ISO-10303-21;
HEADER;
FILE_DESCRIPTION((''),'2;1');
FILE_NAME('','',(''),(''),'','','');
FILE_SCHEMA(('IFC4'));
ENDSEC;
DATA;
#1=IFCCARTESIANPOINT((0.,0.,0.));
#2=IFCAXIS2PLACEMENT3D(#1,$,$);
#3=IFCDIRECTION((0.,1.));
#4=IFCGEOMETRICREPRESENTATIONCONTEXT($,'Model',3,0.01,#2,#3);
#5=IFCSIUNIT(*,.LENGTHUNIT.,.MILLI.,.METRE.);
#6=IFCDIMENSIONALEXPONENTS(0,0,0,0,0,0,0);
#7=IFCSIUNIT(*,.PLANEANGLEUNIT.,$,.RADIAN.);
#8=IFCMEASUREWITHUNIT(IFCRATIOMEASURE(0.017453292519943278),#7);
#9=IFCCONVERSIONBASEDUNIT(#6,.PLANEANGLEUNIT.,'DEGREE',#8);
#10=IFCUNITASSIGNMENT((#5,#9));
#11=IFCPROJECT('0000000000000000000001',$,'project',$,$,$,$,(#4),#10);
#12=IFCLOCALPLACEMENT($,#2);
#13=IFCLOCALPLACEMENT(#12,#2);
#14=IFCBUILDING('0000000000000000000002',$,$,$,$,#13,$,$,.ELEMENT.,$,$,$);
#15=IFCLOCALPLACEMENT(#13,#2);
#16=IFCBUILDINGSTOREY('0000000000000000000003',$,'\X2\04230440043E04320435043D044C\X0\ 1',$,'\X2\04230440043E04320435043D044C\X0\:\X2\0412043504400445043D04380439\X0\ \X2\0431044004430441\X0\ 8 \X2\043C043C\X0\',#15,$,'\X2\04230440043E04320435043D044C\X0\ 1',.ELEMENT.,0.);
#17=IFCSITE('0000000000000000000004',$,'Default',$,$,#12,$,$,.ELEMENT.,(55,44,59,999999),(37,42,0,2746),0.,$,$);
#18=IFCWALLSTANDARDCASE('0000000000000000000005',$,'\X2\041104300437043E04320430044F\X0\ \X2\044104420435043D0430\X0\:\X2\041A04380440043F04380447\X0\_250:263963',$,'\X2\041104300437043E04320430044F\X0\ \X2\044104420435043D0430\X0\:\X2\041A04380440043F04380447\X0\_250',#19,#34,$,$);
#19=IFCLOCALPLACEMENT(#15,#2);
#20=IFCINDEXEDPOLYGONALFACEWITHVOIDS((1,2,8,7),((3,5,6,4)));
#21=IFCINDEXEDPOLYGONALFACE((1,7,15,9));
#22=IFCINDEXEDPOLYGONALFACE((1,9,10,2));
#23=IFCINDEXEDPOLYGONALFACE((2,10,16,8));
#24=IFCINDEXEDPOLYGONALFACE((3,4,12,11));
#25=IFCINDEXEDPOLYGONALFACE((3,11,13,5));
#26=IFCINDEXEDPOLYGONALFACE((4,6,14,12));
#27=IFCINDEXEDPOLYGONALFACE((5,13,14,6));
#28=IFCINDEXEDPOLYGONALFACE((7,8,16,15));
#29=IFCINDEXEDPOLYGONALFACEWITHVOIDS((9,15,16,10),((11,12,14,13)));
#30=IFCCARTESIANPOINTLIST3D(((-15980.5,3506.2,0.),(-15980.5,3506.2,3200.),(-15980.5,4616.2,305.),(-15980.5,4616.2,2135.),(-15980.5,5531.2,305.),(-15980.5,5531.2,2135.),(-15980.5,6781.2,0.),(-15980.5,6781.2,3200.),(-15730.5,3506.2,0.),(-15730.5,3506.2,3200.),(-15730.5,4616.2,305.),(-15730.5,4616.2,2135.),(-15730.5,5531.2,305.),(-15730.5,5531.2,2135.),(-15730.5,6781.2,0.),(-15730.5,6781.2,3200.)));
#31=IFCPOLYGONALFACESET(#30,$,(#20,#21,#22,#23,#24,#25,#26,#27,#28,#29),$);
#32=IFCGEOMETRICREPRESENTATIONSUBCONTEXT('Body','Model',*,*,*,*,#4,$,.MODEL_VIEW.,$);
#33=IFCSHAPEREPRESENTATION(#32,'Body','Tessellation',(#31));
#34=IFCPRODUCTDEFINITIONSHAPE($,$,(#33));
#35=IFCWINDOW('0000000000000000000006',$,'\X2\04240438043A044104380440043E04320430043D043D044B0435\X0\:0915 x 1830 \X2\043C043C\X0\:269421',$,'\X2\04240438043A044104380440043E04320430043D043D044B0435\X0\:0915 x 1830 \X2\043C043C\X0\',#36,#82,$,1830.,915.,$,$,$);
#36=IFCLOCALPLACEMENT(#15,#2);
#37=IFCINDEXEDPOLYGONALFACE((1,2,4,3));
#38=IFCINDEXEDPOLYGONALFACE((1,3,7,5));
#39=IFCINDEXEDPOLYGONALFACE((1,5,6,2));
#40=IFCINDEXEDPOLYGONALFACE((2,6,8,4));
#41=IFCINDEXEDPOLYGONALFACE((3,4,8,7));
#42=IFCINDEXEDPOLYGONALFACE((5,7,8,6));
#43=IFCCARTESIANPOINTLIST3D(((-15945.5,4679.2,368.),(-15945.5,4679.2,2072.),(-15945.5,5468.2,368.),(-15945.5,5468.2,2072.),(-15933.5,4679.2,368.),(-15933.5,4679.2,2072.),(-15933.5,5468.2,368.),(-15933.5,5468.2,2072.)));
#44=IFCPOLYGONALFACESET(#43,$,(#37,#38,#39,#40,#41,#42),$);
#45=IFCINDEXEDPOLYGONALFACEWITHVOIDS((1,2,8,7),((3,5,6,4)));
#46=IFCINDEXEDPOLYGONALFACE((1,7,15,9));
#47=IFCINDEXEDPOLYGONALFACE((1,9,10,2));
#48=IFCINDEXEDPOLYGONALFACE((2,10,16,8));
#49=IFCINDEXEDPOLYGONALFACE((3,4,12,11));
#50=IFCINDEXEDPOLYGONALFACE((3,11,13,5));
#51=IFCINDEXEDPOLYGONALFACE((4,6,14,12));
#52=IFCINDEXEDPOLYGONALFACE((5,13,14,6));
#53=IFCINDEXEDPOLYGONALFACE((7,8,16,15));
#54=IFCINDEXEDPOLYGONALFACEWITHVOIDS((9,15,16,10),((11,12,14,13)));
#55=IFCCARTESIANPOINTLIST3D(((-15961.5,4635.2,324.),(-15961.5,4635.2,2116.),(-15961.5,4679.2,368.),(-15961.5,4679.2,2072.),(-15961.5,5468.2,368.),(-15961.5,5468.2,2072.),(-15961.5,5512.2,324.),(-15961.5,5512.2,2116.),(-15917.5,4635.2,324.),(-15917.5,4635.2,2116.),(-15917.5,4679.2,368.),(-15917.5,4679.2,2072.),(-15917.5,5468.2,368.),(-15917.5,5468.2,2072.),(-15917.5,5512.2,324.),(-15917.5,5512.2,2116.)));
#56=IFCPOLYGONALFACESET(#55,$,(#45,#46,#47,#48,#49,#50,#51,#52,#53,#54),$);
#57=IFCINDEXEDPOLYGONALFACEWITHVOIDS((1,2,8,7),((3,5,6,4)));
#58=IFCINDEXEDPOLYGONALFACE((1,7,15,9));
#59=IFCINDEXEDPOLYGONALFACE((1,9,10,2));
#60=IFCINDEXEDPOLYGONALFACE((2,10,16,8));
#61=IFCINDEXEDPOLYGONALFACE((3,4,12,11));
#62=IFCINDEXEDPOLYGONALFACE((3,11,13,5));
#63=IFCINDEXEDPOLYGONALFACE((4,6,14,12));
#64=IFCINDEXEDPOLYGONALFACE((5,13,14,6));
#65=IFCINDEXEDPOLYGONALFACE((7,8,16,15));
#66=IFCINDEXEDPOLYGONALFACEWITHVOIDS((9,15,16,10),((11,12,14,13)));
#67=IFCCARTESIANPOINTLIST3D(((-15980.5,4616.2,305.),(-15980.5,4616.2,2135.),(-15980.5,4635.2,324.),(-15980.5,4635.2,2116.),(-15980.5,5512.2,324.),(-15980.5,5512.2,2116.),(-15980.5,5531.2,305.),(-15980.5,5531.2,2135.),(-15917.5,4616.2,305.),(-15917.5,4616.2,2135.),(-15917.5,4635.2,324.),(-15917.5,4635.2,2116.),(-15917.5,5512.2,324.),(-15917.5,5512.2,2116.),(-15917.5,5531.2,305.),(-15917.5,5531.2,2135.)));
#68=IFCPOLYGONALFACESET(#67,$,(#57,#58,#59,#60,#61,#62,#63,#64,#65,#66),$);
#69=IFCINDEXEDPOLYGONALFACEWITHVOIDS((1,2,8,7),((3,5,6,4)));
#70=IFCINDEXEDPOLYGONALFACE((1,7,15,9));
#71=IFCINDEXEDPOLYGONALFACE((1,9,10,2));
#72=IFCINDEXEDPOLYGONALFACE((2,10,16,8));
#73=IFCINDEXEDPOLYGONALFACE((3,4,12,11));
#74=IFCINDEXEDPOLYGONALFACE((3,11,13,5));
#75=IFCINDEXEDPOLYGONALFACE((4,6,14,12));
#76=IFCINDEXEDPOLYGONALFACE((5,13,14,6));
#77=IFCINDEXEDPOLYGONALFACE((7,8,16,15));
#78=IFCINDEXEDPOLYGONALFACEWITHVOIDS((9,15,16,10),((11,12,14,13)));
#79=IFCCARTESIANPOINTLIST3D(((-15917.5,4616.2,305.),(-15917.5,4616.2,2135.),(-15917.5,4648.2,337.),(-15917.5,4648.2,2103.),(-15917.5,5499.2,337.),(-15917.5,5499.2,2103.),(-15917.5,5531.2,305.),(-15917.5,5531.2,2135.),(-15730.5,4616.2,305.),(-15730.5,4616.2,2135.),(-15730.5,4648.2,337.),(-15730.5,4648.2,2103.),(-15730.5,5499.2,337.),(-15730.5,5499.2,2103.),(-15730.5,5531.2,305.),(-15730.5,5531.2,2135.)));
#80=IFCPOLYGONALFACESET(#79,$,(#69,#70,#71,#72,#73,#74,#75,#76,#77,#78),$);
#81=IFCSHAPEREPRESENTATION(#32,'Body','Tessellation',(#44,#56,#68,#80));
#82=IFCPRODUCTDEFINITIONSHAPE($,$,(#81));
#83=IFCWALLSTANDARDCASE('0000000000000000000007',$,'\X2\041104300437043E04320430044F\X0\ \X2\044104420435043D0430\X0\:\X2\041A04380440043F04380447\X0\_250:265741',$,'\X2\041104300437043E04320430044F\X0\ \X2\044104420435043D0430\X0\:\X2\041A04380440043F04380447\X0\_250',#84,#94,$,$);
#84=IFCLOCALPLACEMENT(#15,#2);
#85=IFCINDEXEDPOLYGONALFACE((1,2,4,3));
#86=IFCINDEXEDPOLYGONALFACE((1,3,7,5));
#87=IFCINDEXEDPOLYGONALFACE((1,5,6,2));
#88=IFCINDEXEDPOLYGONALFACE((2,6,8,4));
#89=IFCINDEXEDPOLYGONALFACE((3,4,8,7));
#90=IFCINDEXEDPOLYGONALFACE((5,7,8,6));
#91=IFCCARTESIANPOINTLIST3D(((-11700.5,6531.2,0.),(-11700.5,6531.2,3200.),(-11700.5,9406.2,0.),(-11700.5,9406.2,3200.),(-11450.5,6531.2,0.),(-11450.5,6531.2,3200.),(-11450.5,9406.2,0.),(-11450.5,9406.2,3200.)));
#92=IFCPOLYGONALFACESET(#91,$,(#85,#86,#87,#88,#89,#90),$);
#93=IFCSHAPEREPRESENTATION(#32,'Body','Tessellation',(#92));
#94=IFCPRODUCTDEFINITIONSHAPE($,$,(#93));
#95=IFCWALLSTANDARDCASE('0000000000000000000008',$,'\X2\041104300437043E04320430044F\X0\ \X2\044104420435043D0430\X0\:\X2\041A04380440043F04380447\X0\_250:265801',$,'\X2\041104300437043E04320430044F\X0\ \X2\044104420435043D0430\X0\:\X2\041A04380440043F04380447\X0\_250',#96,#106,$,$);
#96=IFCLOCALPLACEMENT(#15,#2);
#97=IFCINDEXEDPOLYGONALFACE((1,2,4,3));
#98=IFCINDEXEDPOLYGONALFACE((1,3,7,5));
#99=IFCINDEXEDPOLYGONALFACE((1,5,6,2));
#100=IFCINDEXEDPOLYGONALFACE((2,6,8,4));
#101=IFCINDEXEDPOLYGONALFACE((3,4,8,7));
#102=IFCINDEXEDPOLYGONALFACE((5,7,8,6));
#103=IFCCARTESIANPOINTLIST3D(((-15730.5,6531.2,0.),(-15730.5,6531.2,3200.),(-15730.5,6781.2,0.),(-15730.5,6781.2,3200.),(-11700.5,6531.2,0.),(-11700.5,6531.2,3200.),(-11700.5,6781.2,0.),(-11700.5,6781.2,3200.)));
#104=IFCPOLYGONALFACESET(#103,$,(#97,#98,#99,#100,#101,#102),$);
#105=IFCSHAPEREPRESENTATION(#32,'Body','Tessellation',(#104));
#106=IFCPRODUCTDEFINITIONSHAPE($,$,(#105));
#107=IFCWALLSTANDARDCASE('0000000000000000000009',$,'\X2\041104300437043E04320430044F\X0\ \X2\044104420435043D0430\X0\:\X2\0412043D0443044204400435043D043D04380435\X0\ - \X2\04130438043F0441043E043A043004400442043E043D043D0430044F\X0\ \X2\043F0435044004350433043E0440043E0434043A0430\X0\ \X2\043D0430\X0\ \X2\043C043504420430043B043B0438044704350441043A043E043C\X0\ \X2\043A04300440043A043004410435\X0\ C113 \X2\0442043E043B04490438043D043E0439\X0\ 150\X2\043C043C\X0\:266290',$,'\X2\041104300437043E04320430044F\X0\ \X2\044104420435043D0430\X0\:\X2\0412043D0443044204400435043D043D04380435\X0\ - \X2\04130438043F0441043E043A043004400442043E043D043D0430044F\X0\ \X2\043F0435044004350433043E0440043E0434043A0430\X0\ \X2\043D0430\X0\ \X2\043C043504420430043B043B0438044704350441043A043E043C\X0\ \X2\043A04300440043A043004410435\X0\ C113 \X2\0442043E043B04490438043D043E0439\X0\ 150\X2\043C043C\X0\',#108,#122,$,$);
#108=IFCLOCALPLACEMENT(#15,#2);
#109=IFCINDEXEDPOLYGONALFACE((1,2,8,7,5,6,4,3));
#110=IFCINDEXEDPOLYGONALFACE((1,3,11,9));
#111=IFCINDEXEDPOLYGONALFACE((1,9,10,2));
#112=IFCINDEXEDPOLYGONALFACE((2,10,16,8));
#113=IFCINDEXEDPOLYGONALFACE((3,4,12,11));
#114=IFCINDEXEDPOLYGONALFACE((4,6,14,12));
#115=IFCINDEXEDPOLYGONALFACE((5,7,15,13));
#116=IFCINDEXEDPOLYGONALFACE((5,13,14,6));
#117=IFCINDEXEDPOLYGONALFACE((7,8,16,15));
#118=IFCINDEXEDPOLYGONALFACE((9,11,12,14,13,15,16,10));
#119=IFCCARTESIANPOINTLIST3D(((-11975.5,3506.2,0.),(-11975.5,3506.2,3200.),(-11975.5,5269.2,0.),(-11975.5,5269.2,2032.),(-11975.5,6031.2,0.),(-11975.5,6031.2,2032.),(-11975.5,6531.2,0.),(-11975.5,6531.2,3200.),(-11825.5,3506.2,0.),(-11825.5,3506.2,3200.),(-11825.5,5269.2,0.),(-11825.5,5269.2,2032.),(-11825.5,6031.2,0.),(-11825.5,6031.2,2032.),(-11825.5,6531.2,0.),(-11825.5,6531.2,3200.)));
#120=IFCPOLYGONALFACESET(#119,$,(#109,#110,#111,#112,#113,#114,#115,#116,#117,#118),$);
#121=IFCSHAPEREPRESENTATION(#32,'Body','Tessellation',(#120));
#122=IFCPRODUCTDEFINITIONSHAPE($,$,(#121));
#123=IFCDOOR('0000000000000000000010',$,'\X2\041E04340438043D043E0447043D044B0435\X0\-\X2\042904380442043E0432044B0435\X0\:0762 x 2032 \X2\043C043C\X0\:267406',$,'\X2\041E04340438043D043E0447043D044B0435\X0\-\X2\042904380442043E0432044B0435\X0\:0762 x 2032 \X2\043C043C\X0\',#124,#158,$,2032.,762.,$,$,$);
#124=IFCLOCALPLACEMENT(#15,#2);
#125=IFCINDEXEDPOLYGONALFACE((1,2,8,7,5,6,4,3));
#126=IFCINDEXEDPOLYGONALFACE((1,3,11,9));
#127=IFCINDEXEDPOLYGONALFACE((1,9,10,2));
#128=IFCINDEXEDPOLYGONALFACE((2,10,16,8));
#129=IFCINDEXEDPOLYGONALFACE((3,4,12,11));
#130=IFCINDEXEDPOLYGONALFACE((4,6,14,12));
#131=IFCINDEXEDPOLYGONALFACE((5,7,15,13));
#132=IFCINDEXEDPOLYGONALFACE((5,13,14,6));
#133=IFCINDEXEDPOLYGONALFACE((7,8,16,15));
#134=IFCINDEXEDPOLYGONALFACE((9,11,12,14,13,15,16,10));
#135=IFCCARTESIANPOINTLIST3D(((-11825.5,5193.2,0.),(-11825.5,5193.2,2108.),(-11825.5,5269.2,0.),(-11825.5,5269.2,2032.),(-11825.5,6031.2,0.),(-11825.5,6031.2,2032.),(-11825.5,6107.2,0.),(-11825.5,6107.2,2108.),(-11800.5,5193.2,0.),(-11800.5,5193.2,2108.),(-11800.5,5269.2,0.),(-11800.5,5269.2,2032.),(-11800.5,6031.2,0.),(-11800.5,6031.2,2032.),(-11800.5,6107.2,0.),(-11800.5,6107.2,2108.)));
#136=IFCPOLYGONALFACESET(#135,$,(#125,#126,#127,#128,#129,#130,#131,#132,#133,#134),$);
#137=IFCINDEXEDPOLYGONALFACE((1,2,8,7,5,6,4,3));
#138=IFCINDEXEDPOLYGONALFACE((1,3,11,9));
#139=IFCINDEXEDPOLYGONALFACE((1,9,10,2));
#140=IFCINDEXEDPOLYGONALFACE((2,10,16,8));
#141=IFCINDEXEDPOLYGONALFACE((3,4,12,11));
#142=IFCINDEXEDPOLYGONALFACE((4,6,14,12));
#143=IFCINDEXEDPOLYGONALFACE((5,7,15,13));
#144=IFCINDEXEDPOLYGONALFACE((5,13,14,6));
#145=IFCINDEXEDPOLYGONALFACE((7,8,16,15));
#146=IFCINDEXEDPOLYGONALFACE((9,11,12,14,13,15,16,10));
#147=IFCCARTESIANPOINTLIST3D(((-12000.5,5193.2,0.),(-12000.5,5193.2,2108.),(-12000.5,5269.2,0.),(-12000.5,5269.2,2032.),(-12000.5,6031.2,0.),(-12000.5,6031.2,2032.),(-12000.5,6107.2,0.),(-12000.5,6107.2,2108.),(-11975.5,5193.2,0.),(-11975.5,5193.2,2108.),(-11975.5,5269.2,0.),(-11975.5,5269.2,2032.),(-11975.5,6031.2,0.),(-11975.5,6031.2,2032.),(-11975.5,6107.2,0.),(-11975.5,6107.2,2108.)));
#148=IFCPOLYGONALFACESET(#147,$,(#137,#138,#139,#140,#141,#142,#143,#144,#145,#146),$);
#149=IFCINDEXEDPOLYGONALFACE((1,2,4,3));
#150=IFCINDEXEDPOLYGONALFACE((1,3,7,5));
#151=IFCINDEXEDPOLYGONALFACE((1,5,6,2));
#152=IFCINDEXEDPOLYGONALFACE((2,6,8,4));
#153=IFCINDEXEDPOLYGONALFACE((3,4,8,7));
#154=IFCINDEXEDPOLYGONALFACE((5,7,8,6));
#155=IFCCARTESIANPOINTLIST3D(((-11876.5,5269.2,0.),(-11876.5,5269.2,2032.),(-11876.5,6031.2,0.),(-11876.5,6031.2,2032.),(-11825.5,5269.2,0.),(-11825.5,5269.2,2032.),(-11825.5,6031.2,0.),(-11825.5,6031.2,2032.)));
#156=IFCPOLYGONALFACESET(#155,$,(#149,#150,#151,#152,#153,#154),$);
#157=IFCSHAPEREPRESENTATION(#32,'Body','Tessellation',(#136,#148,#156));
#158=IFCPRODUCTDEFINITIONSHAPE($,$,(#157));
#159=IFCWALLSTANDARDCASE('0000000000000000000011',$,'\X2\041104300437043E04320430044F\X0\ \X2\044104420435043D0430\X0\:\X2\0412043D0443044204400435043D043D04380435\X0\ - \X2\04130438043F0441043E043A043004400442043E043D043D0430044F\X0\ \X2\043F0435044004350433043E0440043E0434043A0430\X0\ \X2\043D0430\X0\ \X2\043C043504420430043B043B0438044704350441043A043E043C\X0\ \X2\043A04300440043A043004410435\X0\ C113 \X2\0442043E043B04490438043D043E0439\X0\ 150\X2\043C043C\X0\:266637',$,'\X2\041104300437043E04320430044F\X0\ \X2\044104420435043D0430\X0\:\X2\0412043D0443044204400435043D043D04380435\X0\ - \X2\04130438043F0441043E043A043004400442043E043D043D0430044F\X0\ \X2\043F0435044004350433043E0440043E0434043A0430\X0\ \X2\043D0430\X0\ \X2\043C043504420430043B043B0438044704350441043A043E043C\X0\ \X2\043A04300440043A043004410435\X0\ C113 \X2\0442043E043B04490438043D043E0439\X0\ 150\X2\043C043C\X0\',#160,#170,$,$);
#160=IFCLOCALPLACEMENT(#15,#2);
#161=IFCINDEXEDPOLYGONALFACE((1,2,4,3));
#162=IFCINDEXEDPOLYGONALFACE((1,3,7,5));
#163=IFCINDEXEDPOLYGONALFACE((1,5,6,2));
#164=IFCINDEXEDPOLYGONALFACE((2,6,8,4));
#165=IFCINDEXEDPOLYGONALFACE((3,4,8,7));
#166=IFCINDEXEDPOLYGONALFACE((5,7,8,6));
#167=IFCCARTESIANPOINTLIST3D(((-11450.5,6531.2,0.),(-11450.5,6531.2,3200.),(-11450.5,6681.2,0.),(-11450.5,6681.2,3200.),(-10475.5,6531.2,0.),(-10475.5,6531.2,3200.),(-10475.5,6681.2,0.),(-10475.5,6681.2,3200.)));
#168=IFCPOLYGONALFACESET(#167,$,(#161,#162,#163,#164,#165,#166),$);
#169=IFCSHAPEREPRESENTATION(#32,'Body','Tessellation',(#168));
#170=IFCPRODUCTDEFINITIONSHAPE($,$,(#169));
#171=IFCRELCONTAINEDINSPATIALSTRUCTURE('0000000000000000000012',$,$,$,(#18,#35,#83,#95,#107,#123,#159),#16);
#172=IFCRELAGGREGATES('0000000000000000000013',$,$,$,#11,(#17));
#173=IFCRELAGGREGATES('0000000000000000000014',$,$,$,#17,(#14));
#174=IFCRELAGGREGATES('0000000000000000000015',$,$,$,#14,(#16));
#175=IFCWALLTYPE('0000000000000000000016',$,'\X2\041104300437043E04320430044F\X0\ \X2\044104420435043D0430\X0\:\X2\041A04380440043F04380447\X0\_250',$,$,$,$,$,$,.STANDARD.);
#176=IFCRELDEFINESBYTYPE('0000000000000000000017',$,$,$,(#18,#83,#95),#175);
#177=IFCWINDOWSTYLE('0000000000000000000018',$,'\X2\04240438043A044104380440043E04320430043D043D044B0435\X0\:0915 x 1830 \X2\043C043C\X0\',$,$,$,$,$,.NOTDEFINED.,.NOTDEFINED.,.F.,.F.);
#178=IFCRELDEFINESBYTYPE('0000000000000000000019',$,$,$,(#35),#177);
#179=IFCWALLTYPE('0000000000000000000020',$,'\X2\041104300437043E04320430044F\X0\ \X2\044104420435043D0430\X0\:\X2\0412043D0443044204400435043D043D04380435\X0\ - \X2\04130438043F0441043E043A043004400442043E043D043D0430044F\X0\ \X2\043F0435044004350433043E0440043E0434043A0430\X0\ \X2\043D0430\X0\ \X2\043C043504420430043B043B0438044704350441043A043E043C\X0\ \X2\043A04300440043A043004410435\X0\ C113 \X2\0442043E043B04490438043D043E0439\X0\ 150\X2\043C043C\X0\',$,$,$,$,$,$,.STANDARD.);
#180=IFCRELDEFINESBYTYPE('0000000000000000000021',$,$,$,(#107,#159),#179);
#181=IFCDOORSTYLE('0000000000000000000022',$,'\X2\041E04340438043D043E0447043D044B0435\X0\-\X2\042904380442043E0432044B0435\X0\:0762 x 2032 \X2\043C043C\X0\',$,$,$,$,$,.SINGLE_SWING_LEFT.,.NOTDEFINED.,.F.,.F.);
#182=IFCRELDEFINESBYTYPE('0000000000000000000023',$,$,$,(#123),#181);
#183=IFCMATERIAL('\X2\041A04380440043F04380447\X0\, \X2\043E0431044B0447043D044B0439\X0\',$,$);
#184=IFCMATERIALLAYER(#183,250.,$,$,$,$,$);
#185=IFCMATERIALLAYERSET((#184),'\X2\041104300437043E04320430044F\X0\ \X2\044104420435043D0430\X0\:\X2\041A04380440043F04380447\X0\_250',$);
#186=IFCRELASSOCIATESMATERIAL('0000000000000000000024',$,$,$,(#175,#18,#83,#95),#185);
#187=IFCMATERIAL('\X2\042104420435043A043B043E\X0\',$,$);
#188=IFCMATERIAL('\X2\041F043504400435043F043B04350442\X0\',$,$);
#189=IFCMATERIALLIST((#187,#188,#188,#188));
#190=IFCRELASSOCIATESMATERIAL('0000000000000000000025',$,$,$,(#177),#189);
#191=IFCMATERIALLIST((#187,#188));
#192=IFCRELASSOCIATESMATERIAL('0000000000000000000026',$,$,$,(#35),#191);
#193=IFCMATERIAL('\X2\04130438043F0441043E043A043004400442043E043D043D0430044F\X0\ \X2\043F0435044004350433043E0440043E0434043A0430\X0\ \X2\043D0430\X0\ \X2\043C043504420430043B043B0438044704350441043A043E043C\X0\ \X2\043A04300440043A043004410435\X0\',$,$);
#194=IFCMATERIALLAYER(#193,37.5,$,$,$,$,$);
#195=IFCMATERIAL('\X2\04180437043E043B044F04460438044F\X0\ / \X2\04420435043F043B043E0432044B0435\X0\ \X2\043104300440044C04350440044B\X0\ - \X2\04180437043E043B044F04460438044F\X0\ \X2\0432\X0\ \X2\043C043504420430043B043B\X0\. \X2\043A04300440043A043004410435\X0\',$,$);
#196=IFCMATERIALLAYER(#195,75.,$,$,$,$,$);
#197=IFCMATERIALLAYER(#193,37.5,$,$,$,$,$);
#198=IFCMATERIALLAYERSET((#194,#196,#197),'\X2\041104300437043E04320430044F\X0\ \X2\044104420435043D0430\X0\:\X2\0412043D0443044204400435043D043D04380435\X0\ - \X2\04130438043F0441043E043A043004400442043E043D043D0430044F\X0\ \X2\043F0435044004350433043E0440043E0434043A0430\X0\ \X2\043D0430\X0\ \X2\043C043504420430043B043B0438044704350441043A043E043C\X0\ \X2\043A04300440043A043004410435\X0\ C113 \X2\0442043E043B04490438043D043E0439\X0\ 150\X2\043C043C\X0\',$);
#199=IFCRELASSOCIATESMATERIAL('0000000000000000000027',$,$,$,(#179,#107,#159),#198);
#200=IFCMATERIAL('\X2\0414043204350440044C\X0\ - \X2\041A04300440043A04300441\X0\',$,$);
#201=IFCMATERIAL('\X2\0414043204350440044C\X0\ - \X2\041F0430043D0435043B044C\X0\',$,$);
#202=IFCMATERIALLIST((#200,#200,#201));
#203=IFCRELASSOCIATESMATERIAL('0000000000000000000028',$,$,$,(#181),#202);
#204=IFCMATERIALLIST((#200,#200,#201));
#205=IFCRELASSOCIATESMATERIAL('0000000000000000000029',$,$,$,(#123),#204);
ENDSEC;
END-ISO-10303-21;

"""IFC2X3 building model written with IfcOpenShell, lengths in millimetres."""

from ifc_helpers import new_model, entity, si_unit, converted_unit, direction, frame, frame_2d, origin, place, context, subcontext, project, spatial, polyline, rectangle, outline, extrude, source, transform, mapped, material, material_list, layer, layer_set, layer_usage, type_object, type_shapes, element, fill, save


model = new_model("IFC2X3")

# Units and contexts
model_context = context("Model", 3, precision=0.01, world=origin(), true_north=direction((0.0, 1.0)))
body_context = subcontext(model_context, "Body", "Model", "MODEL_VIEW")
ifc_project = project(units=[si_unit("LENGTHUNIT", "METRE", prefix="MILLI"), converted_unit("PLANEANGLEUNIT", "DEGREE", entity("IfcRatioMeasure", 0.017453292519943278), si_unit("PLANEANGLEUNIT", "RADIAN"), dimensions=[0, 0, 0, 0, 0, 0, 0])], contexts=[model_context])

# Site, building, storey
site_placement = place(None, origin())
site = spatial("IfcSite", under=ifc_project, at=site_placement, Name="Default", CompositionType="ELEMENT", RefLatitude=(55, 44, 59, 999999), RefLongitude=(37, 42, 0, 2746), RefElevation=0.0)
building_placement = place(site_placement, origin())
building = spatial("IfcBuilding", under=site, at=building_placement, CompositionType="ELEMENT")
storey_placement = place(building_placement, origin())
storey = spatial("IfcBuildingStorey", under=building, at=storey_placement, Name="Уровень 1", ObjectType="Уровень:Верхний брус 8 мм", LongName="Уровень 1", CompositionType="ELEMENT", Elevation=0.0)

# Shared definitions
ifc_material_1 = material(Name="Кирпич, обычный")
ifc_layer_1 = layer(ifc_material_1, 250.0)
ifc_layer_set_1 = layer_set([ifc_layer_1], Name="Базовая стена:Кирпич_250")
wall_type_1 = type_object("IfcWallType", Name="Базовая стена:Кирпич_250", PredefinedType="STANDARD", material=ifc_layer_set_1)
ifc_material_2 = material(Name="Дверь - Каркас")
ifc_material_3 = material(Name="Дверь - Панель")
ifc_material_4 = material(Name="Стекло")
ifc_material_5 = material(Name="Переплет")
ifc_material_list_1 = material_list([ifc_material_4, ifc_material_5, ifc_material_5, ifc_material_5])
window_style_1 = type_object("IfcWindowStyle", Name="Фиксированные:0915 x 1830 мм", ConstructionType="NOTDEFINED", OperationType="NOTDEFINED", ParameterTakesPrecedence=False, Sizeable=False, material=ifc_material_list_1)
shared_shape_1 = source(origin(), body_context, "Body", "SweptSolid", [
    extrude(rectangle(XDim=12.0, YDim=789.0, at=frame_2d((0.0, 0.0), x_axis=(1.0, 0.0))), frame((457.5, 209.0, 63.0), z_axis=(0.0, 0.0, 1.0), x_axis=(0.0, -1.0, 0.0)), (0.0, 0.0, 1.0), 1704.0),
    extrude(outline(polyline([(-438.5, -896.0), (438.5, -896.0), (438.5, 896.0), (-438.5, 896.0), (-438.5, -896.0)]), holes=[polyline([(-394.5, -852.0), (-394.5, 852.0), (394.5, 852.0), (394.5, -852.0), (-394.5, -852.0)])]), frame((457.5, 187.0, 915.0), z_axis=(0.0, 1.0, 0.0), x_axis=(1.0, 0.0, 0.0)), (0.0, 0.0, 1.0), 44.0),
    extrude(outline(polyline([(-457.5, -915.0), (457.5, -915.0), (457.5, 915.0), (-457.5, 915.0), (-457.5, -915.0)]), holes=[polyline([(-438.5, -896.0), (-438.5, 896.0), (438.5, 896.0), (438.5, -896.0), (-438.5, -896.0)])]), frame((457.5, 187.0, 915.0), z_axis=(0.0, 1.0, 0.0), x_axis=(1.0, 0.0, 0.0)), (0.0, 0.0, 1.0), 63.0),
    extrude(outline(polyline([(-457.5, -915.0), (457.5, -915.0), (457.5, 915.0), (-457.5, 915.0), (-457.5, -915.0)]), holes=[polyline([(-425.5, -883.0), (-425.5, 883.0), (425.5, 883.0), (425.5, -883.0), (-425.5, -883.0)])]), frame((457.5, 0.0, 915.0), z_axis=(0.0, 1.0, 0.0), x_axis=(1.0, 0.0, 0.0)), (0.0, 0.0, 1.0), 187.0),
])
type_shapes(window_style_1, [shared_shape_1])

# Wall, opening, window
ifc_layer_usage_1 = layer_usage(ifc_layer_set_1, "AXIS2", "NEGATIVE", 125.0)
wall_1_placement = place(storey_placement, frame((-15855.5, 6781.2, 0.0), z_axis=(0.0, 0.0, 1.0), x_axis=(0.0, -1.0, 0.0)))
wall_1 = element("IfcWallStandardCase", 1, at=wall_1_placement, inside=storey, type_object=wall_type_1, material=ifc_layer_usage_1, Name="Базовая стена:Кирпич_250:263963", ObjectType="Базовая стена:Кирпич_250", context=body_context, shape_type="SweptSolid", body=[
    extrude(rectangle(XDim=3275.0, YDim=250.0, at=frame_2d((1637.5, 0.0), x_axis=(-1.0, 0.0))), origin(), (0.0, 0.0, 1.0), 3200.0),
])
opening_1_placement = place(wall_1_placement, frame((2165.0, 125.0, 305.0)))
opening_1 = element("IfcOpeningElement", 2, at=opening_1_placement, cuts=wall_1, ObjectType="Opening", context=body_context, shape_type="SweptSolid", body=[
    extrude(rectangle(XDim=1830.0, YDim=915.0, at=frame_2d((915.0, 457.5), x_axis=(1.0, 0.0))), frame((0.0, 0.0, 0.0), z_axis=(0.0, -1.0, 0.0), x_axis=(0.0, 0.0, 1.0)), (0.0, 0.0, 1.0), 250.0),
])
ifc_material_list_2 = material_list([ifc_material_4, ifc_material_5])
window_1_placement = place(opening_1_placement, frame((0.0, 0.0, 0.0), z_axis=(0.0, 0.0, 1.0), x_axis=(-1.0, 0.0, 0.0)))
window_1 = element("IfcWindow", 3, at=window_1_placement, inside=storey, type_object=window_style_1, material=ifc_material_list_2, Name="Фиксированные:0915 x 1830 мм:269421", ObjectType="Фиксированные:0915 x 1830 мм", OverallHeight=1830.0, OverallWidth=915.0, context=body_context, shape_type="MappedRepresentation", body=[
    mapped(shared_shape_1, transform((0.0, 0.0, 0.0), scale=1.0)),
])
fill(opening_1, window_1)

# Walls
ifc_layer_usage_2 = layer_usage(ifc_layer_set_1, "AXIS2", "NEGATIVE", 125.0)
wall_2_placement = place(storey_placement, frame((-11575.5, 9406.2, 0.0), z_axis=(0.0, 0.0, 1.0), x_axis=(0.0, -1.0, 0.0)))
element("IfcWallStandardCase", 4, at=wall_2_placement, inside=storey, type_object=wall_type_1, material=ifc_layer_usage_2, Name="Базовая стена:Кирпич_250:265741", ObjectType="Базовая стена:Кирпич_250", context=body_context, shape_type="SweptSolid", body=[
    extrude(rectangle(XDim=2875.0, YDim=250.0, at=frame_2d((1437.5, 0.0), x_axis=(-1.0, 0.0))), origin(), (0.0, 0.0, 1.0), 3200.0),
])
ifc_layer_usage_3 = layer_usage(ifc_layer_set_1, "AXIS2", "NEGATIVE", 125.0)
wall_3_placement = place(storey_placement, frame((-11700.5, 6656.2, 0.0), z_axis=(0.0, 0.0, 1.0), x_axis=(-1.0, 0.0, 0.0)))
element("IfcWallStandardCase", 5, at=wall_3_placement, inside=storey, type_object=wall_type_1, material=ifc_layer_usage_3, Name="Базовая стена:Кирпич_250:265801", ObjectType="Базовая стена:Кирпич_250", context=body_context, shape_type="SweptSolid", body=[
    extrude(rectangle(XDim=4030.0, YDim=250.0, at=frame_2d((2015.0, 0.0), x_axis=(-1.0, 0.0))), origin(), (0.0, 0.0, 1.0), 3200.0),
])

# Wall, opening, door
ifc_material_6 = material(Name="Гипсокартонная перегородка на металлическом каркасе")
ifc_layer_2 = layer(ifc_material_6, 37.5)
ifc_material_7 = material(Name="Изоляция / тепловые барьеры - Изоляция в металл. каркасе")
ifc_layer_3 = layer(ifc_material_7, 75.0)
ifc_layer_4 = layer(ifc_material_6, 37.5)
ifc_layer_set_2 = layer_set([ifc_layer_2, ifc_layer_3, ifc_layer_4], Name="Базовая стена:Внутренние - Гипсокартонная перегородка на металлическом каркасе C113 толщиной 150мм")
ifc_layer_usage_4 = layer_usage(ifc_layer_set_2, "AXIS2", "NEGATIVE", 75.0)
wall_type_2 = type_object("IfcWallType", Name="Базовая стена:Внутренние - Гипсокартонная перегородка на металлическом каркасе C113 толщиной 150мм", PredefinedType="STANDARD", material=ifc_layer_set_2)
wall_4_placement = place(storey_placement, frame((-11900.5, 3506.2, 0.0), z_axis=(0.0, 0.0, 1.0), x_axis=(0.0, 1.0, 0.0)))
wall_4 = element("IfcWallStandardCase", 6, at=wall_4_placement, inside=storey, type_object=wall_type_2, material=ifc_layer_usage_4, Name="Базовая стена:Внутренние - Гипсокартонная перегородка на металлическом каркасе C113 толщиной 150мм:266290", ObjectType="Базовая стена:Внутренние - Гипсокартонная перегородка на металлическом каркасе C113 толщиной 150мм", context=body_context, shape_type="SweptSolid", body=[
    extrude(rectangle(XDim=3025.0, YDim=150.0, at=frame_2d((1512.5, 0.0), x_axis=(-1.0, 0.0))), origin(), (0.0, 0.0, 1.0), 3200.0),
])
opening_2_placement = place(wall_4_placement, frame((2525.0, 75.0, 0.0)))
opening_2 = element("IfcOpeningElement", 7, at=opening_2_placement, cuts=wall_4, ObjectType="Opening", context=body_context, shape_type="SweptSolid", body=[
    extrude(rectangle(XDim=762.0, YDim=2032.0, at=frame_2d((1016.0, 381.0), x_axis=(0.0, -1.0))), frame((0.0, 0.0, 0.0), z_axis=(0.0, -1.0, 0.0), x_axis=(0.0, 0.0, 1.0)), (0.0, 0.0, 1.0), 150.0),
])
ifc_material_list_3 = material_list([ifc_material_2, ifc_material_2, ifc_material_3])
ifc_material_list_4 = material_list([ifc_material_2, ifc_material_2, ifc_material_3])
door_style_1 = type_object("IfcDoorStyle", Name="Одиночные-Щитовые:0762 x 2032 мм", ConstructionType="NOTDEFINED", OperationType="SINGLE_SWING_LEFT", ParameterTakesPrecedence=False, Sizeable=False, material=ifc_material_list_4)
shared_shape_2 = source(origin(), body_context, "Body", "SweptSolid", [
    extrude(outline(polyline([(-457.0, -1073.0), (457.0, -1073.0), (457.0, 1035.0), (381.0, 1035.0), (381.0, -997.0), (-381.0, -997.0), (-381.0, 1035.0), (-457.0, 1035.0), (-457.0, -1073.0)])), frame((381.0, 175.0, 1035.0), z_axis=(0.0, -1.0, 0.0), x_axis=(-1.0, 0.0, 0.0)), (0.0, 0.0, 1.0), 25.0),
    extrude(outline(polyline([(-1073.0, -457.0), (1035.0, -457.0), (1035.0, -381.0), (-997.0, -381.0), (-997.0, 381.0), (1035.0, 381.0), (1035.0, 457.0), (-1073.0, 457.0), (-1073.0, -457.0)])), frame((381.0, 0.0, 1035.0), z_axis=(0.0, -1.0, 0.0), x_axis=(0.0, 0.0, -1.0)), (0.0, 0.0, 1.0), 25.0),
    extrude(rectangle(XDim=762.0, YDim=51.0, at=frame_2d((0.0, 0.0), x_axis=(1.0, 0.0))), frame((381.0, 124.5, 0.0)), (0.0, 0.0, 1.0), 2032.0),
])
type_shapes(door_style_1, [shared_shape_2])
door_1_placement = place(opening_2_placement, frame((0.0, 0.0, 0.0), z_axis=(0.0, 0.0, 1.0), x_axis=(-1.0, 0.0, 0.0)))
door_1 = element("IfcDoor", 8, at=door_1_placement, inside=storey, type_object=door_style_1, material=ifc_material_list_3, Name="Одиночные-Щитовые:0762 x 2032 мм:267406", ObjectType="Одиночные-Щитовые:0762 x 2032 мм", OverallHeight=2032.0, OverallWidth=762.0, context=body_context, shape_type="MappedRepresentation", body=[
    mapped(shared_shape_2, transform((0.0, 0.0, 0.0), scale=1.0)),
])
fill(opening_2, door_1)

# Wall
ifc_layer_usage_5 = layer_usage(ifc_layer_set_2, "AXIS2", "NEGATIVE", 75.0)
wall_5_placement = place(storey_placement, frame((-11450.5, 6606.2, 0.0)))
element("IfcWallStandardCase", 9, at=wall_5_placement, inside=storey, type_object=wall_type_2, material=ifc_layer_usage_5, Name="Базовая стена:Внутренние - Гипсокартонная перегородка на металлическом каркасе C113 толщиной 150мм:266637", ObjectType="Базовая стена:Внутренние - Гипсокартонная перегородка на металлическом каркасе C113 толщиной 150мм", context=body_context, shape_type="SweptSolid", body=[
    extrude(rectangle(XDim=975.0, YDim=150.0, at=frame_2d((487.5, 0.0), x_axis=(-1.0, 0.0))), origin(), (0.0, 0.0, 1.0), 3200.0),
])

save(model, "model.ifc")
